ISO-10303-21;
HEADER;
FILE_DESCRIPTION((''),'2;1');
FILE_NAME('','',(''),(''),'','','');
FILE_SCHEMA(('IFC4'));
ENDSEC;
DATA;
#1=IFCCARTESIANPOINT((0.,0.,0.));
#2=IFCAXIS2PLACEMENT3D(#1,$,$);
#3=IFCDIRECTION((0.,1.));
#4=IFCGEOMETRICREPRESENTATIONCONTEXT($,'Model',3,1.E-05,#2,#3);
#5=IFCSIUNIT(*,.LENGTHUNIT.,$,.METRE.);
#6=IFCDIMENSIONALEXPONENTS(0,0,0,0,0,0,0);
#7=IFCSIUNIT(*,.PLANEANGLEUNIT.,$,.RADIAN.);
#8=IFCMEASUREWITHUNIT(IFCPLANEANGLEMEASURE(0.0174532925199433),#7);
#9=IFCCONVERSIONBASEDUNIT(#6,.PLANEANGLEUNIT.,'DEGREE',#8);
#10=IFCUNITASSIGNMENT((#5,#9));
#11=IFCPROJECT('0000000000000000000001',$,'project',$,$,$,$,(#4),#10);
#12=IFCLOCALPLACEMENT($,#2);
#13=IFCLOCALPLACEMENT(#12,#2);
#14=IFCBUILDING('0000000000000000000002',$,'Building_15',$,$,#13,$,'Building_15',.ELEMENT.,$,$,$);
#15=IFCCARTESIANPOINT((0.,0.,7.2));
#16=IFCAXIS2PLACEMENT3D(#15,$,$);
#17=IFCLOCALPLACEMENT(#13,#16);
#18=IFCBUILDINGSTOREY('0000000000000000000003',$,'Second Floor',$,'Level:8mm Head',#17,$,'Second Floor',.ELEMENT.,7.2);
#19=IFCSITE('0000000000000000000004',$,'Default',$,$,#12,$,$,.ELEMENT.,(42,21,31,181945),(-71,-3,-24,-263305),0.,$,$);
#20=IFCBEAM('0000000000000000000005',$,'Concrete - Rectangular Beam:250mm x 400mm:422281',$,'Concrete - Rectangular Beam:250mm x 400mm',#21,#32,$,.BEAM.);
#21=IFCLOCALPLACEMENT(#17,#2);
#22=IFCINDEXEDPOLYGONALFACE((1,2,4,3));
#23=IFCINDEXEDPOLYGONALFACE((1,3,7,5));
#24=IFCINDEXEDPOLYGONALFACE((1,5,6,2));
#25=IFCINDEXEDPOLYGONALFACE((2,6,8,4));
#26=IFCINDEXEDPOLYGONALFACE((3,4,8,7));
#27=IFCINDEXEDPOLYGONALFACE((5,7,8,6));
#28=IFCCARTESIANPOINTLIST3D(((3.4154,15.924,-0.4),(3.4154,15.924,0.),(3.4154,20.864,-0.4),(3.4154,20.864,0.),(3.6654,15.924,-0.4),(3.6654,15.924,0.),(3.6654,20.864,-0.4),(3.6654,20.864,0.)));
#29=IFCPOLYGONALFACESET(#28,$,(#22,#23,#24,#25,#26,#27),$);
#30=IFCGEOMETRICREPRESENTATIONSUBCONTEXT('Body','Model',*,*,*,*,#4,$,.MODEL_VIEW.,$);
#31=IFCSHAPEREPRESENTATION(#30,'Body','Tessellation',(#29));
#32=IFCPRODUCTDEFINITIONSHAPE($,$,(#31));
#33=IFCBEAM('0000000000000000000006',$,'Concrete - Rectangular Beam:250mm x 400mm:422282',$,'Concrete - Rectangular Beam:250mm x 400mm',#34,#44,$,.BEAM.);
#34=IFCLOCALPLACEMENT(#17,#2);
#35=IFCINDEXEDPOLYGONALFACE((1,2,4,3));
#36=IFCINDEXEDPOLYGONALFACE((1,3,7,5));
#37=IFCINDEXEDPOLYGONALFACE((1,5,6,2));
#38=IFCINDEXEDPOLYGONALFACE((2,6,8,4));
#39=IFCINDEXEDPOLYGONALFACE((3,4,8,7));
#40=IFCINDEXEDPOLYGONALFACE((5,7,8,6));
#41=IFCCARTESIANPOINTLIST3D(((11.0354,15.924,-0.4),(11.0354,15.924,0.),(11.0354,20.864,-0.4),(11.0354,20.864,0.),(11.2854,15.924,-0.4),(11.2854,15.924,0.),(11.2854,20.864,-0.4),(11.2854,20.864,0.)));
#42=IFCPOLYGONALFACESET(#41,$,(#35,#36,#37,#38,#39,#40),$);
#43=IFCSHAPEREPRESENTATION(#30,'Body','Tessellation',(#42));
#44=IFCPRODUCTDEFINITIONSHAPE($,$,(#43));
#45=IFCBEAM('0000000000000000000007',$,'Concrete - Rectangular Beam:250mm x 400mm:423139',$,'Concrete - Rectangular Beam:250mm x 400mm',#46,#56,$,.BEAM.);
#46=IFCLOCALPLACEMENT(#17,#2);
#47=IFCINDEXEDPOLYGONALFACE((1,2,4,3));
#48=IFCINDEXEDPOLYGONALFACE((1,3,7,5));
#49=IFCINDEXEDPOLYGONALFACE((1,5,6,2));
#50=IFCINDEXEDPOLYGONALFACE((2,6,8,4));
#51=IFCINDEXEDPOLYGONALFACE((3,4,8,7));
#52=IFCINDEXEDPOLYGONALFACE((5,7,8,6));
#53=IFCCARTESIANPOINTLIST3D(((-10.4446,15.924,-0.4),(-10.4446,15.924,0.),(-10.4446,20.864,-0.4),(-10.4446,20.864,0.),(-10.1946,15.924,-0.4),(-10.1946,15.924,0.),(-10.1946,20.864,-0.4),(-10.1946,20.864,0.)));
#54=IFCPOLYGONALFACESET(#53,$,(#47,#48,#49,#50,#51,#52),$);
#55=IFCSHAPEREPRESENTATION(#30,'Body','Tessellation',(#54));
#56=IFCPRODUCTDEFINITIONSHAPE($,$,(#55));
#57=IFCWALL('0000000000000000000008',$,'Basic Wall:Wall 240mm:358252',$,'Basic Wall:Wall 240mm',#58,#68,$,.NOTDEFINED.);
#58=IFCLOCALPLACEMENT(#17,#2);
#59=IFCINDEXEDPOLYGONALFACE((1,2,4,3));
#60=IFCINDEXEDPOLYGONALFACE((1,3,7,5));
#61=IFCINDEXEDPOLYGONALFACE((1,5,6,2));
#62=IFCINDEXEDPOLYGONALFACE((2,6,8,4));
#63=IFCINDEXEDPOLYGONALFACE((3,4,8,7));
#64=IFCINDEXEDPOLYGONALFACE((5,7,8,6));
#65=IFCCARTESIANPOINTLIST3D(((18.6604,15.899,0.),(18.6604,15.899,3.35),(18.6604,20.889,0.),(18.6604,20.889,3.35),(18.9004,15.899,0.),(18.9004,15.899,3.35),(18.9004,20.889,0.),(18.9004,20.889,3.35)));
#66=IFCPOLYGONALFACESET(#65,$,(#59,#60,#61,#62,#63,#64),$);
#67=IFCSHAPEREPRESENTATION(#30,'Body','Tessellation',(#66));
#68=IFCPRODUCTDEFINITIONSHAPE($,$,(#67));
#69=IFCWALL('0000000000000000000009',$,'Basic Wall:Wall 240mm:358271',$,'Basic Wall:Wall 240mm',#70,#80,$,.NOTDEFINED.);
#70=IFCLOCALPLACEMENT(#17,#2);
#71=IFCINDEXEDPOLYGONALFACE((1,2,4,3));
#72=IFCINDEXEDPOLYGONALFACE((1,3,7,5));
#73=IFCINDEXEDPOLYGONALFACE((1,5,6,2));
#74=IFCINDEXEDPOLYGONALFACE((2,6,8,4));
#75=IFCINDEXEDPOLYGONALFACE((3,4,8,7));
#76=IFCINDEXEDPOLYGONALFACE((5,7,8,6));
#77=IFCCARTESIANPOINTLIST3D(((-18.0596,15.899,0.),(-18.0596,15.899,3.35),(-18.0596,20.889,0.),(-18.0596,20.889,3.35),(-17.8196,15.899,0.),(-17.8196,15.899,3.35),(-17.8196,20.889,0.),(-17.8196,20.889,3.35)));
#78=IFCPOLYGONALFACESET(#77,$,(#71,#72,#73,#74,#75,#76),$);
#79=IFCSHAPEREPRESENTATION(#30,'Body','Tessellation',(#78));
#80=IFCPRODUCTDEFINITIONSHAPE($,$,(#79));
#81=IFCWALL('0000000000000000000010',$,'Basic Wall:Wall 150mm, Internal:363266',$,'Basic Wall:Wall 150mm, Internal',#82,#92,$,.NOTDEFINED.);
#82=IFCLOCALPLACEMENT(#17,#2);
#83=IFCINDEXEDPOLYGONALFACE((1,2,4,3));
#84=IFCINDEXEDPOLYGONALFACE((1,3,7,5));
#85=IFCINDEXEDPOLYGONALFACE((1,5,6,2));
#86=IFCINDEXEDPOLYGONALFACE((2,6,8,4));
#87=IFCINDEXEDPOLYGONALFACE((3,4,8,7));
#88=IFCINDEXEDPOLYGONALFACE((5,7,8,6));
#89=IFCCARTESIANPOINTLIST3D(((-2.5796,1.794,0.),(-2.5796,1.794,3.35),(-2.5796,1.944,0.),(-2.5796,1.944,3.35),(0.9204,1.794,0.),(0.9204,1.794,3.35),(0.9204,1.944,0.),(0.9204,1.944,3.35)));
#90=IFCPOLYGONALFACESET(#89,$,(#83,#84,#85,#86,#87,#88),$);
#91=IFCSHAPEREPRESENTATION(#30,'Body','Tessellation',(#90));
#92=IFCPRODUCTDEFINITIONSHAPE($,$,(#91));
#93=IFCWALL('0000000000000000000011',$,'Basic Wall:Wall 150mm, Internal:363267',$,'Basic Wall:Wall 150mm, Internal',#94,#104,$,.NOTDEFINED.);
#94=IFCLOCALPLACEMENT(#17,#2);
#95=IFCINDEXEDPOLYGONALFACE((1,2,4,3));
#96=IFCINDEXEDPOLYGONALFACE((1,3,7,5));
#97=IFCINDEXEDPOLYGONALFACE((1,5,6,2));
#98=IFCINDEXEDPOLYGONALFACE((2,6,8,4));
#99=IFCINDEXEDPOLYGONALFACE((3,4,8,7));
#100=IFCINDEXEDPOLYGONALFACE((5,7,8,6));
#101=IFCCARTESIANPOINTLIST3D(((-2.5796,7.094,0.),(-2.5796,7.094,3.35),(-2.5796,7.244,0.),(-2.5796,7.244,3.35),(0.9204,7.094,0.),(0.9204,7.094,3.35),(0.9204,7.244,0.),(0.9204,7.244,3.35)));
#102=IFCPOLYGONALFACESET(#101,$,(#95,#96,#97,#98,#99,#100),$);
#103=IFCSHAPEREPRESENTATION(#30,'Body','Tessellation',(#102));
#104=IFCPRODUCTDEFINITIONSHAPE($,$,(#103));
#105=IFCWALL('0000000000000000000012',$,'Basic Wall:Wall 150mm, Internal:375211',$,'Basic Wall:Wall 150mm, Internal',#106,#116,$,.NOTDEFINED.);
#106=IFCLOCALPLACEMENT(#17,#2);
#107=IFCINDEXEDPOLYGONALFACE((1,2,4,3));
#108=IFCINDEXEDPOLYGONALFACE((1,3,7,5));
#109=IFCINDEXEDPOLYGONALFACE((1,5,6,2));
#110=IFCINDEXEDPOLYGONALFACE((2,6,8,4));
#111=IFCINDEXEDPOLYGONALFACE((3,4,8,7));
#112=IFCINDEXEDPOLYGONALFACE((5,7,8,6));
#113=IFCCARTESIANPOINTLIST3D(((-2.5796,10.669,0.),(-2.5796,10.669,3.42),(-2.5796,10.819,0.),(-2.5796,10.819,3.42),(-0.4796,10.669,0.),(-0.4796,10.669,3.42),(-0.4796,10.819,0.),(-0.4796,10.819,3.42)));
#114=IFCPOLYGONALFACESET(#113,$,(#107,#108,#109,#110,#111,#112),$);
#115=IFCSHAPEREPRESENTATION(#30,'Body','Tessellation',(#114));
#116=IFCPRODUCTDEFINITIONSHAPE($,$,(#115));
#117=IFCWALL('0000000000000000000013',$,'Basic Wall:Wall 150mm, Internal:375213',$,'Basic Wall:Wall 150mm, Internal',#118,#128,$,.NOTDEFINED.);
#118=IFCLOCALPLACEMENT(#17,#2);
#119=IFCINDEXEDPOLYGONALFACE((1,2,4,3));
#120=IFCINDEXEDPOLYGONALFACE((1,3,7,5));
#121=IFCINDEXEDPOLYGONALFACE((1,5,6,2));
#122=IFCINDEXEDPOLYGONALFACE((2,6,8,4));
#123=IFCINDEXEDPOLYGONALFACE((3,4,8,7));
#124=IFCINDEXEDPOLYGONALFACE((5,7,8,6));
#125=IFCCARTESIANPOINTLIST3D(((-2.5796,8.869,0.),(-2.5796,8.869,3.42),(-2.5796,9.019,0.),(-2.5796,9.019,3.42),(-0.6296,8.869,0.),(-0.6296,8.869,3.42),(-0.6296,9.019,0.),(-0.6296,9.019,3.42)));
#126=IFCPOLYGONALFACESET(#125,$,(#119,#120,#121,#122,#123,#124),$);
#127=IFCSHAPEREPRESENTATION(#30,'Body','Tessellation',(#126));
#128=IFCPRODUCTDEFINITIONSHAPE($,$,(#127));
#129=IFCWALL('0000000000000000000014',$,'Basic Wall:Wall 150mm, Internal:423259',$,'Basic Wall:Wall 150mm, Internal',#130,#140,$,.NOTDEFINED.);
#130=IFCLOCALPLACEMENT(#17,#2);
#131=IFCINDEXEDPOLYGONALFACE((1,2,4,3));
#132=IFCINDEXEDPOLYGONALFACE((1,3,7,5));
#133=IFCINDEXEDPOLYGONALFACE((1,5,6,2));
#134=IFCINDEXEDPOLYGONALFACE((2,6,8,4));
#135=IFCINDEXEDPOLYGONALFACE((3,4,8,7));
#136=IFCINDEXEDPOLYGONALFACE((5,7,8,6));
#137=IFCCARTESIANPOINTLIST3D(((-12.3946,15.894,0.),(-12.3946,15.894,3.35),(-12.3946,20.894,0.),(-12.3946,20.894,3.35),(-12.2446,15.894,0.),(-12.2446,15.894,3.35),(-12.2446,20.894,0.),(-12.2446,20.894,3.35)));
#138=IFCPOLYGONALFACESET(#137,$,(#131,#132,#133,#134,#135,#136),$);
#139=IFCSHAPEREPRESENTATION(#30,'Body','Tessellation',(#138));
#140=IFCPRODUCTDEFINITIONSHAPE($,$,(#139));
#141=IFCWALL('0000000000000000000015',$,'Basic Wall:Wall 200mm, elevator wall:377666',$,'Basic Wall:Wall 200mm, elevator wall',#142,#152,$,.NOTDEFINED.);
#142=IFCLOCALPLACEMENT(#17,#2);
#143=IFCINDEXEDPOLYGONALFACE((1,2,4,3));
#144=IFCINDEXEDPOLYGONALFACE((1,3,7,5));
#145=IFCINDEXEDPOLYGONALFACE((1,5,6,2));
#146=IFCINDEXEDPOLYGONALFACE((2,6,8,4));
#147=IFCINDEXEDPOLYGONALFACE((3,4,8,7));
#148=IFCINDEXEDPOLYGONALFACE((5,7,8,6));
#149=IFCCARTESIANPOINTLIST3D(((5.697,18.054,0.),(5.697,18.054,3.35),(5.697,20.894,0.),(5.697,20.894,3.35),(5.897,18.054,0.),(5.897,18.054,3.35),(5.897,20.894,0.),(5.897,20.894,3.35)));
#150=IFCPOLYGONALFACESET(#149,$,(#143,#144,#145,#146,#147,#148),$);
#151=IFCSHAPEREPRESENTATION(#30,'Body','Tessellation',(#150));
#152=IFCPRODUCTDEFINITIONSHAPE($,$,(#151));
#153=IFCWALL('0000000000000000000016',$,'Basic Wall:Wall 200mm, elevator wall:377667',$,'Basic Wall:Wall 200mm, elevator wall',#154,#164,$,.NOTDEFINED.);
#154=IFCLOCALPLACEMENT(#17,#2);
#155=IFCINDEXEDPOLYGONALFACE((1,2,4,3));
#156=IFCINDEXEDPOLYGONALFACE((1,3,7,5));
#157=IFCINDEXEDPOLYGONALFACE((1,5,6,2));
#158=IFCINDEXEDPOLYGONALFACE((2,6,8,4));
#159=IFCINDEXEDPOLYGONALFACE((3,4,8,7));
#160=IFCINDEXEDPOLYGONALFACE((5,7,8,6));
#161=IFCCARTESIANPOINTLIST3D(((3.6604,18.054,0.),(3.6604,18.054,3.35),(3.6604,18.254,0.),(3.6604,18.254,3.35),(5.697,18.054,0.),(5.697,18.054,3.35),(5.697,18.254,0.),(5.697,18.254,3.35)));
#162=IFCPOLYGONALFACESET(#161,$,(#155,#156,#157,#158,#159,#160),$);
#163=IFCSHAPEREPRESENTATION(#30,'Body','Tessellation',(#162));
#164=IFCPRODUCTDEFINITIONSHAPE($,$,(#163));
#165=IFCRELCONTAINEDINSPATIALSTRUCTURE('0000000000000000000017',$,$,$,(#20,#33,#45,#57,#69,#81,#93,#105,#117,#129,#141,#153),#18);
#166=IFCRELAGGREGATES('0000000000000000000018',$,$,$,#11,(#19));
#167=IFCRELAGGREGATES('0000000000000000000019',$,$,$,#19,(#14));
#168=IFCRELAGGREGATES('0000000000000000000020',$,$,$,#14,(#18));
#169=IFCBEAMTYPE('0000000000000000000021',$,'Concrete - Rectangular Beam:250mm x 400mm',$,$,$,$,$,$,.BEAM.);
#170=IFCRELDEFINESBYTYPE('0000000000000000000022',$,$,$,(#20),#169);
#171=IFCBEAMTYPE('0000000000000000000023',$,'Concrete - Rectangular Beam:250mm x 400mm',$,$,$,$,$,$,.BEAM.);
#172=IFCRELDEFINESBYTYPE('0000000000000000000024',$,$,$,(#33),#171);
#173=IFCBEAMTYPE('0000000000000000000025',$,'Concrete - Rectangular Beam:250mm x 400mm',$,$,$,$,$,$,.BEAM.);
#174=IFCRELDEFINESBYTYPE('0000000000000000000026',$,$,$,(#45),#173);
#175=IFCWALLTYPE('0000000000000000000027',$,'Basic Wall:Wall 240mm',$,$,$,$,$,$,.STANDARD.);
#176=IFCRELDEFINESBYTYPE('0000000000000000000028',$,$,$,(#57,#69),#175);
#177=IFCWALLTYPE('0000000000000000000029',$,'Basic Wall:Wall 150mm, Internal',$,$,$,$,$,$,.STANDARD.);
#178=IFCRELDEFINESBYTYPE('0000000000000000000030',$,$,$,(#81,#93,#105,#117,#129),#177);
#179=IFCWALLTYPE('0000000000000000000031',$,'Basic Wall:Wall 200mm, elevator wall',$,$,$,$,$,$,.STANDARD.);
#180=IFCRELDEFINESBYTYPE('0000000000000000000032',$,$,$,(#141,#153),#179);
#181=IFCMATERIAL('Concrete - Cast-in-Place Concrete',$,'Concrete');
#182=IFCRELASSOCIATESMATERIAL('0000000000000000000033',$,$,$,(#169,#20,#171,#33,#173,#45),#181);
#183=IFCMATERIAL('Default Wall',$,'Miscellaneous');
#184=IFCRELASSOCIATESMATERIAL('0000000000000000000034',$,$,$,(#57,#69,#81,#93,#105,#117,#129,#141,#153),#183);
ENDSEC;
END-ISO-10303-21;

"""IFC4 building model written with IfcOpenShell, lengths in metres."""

from ifc_helpers import new_model, entity, si_unit, converted_unit, direction, frame, origin, place, context, subcontext, project, spatial, indexed_curve, outline, extrude, source, transform, mapped, material, type_object, type_shapes, element, save


model = new_model("IFC4")

# Units and contexts
model_context = context("Model", 3, precision=1e-05, world=origin(), true_north=direction((0.0, 1.0)))
body_context = subcontext(model_context, "Body", "Model", "MODEL_VIEW")
ifc_project = project(units=[si_unit("LENGTHUNIT", "METRE"), converted_unit("PLANEANGLEUNIT", "DEGREE", entity("IfcPlaneAngleMeasure", 0.0174532925199433), si_unit("PLANEANGLEUNIT", "RADIAN"), dimensions=[0, 0, 0, 0, 0, 0, 0])], contexts=[model_context])

# Site, building, storey
site_placement = place(None, origin())
site = spatial("IfcSite", under=ifc_project, at=site_placement, Name="Default", CompositionType="ELEMENT", RefLatitude=(42, 21, 31, 181945), RefLongitude=(-71, -3, -24, -263305), RefElevation=0.0)
building_placement = place(site_placement, origin())
building = spatial("IfcBuilding", under=site, at=building_placement, Name="Building_15", LongName="Building_15", CompositionType="ELEMENT")
storey_placement = place(building_placement, frame((0.0, 0.0, 7.2)))
storey = spatial("IfcBuildingStorey", under=building, at=storey_placement, Name="Second Floor", ObjectType="Level:8mm Head", LongName="Second Floor", CompositionType="ELEMENT", Elevation=7.2)

# Shared definitions
ifc_material_1 = material(Name="Concrete - Cast-in-Place Concrete", Category="Concrete")

# Beams
beam_type_1 = type_object("IfcBeamType", Name="Concrete - Rectangular Beam:250mm x 400mm", PredefinedType="BEAM", material=ifc_material_1)
shared_shape_1 = source(origin(), body_context, "Body", "SweptSolid", [
    extrude(outline(indexed_curve([(-0.125, -0.2), (0.125, -0.2), (0.125, 0.2), (-0.125, 0.2), (-0.125, -0.2)], self_intersect=False)), frame((3.5404, 20.864, 7.0), z_axis=(0.0, -1.0, 0.0), x_axis=(-1.0, 0.0, 0.0)), (0.0, 0.0, 1.0), 4.94),
])
type_shapes(beam_type_1, [shared_shape_1])
beam_1_placement = place(storey_placement, frame((0.0, 0.0, -7.2)))
element("IfcBeam", 1, at=beam_1_placement, inside=storey, type_object=beam_type_1, material=ifc_material_1, Name="Concrete - Rectangular Beam:250mm x 400mm:422281", ObjectType="Concrete - Rectangular Beam:250mm x 400mm", PredefinedType="BEAM", context=body_context, shape_type="MappedRepresentation", body=[
    mapped(shared_shape_1, transform((0.0, 0.0, 0.0), scale=1.0)),
])
beam_type_2 = type_object("IfcBeamType", Name="Concrete - Rectangular Beam:250mm x 400mm", PredefinedType="BEAM", material=ifc_material_1)
shared_shape_2 = source(origin(), body_context, "Body", "SweptSolid", [
    extrude(outline(indexed_curve([(-0.125, -0.2), (0.125, -0.2), (0.125, 0.2), (-0.125, 0.2), (-0.125, -0.2)], self_intersect=False)), frame((11.1604, 20.864, 7.0), z_axis=(0.0, -1.0, 0.0), x_axis=(-1.0, 0.0, 0.0)), (0.0, 0.0, 1.0), 4.94),
])
type_shapes(beam_type_2, [shared_shape_2])
beam_2_placement = place(storey_placement, frame((0.0, 0.0, -7.2)))
element("IfcBeam", 2, at=beam_2_placement, inside=storey, type_object=beam_type_2, material=ifc_material_1, Name="Concrete - Rectangular Beam:250mm x 400mm:422282", ObjectType="Concrete - Rectangular Beam:250mm x 400mm", PredefinedType="BEAM", context=body_context, shape_type="MappedRepresentation", body=[
    mapped(shared_shape_2, transform((0.0, 0.0, 0.0), scale=1.0)),
])
beam_type_3 = type_object("IfcBeamType", Name="Concrete - Rectangular Beam:250mm x 400mm", PredefinedType="BEAM", material=ifc_material_1)
shared_shape_3 = source(origin(), body_context, "Body", "SweptSolid", [
    extrude(outline(indexed_curve([(-0.125, -0.2), (0.125, -0.2), (0.125, 0.2), (-0.125, 0.2), (-0.125, -0.2)], self_intersect=False)), frame((-10.3196, 20.864, 7.0), z_axis=(0.0, -1.0, 0.0), x_axis=(-1.0, 0.0, 0.0)), (0.0, 0.0, 1.0), 4.94),
])
type_shapes(beam_type_3, [shared_shape_3])
beam_3_placement = place(storey_placement, frame((0.0, 0.0, -7.2)))
element("IfcBeam", 3, at=beam_3_placement, inside=storey, type_object=beam_type_3, material=ifc_material_1, Name="Concrete - Rectangular Beam:250mm x 400mm:423139", ObjectType="Concrete - Rectangular Beam:250mm x 400mm", PredefinedType="BEAM", context=body_context, shape_type="MappedRepresentation", body=[
    mapped(shared_shape_3, transform((0.0, 0.0, 0.0), scale=1.0)),
])

# Walls
ifc_material_2 = material(Name="Default Wall", Category="Miscellaneous")
wall_type_1 = type_object("IfcWallType", Name="Basic Wall:Wall 240mm", PredefinedType="STANDARD")
wall_1_placement = place(storey_placement, frame((18.7804, 20.889, 0.0), z_axis=(0.0, 0.0, 1.0), x_axis=(0.0, -1.0, 0.0)))
element("IfcWall", 4, at=wall_1_placement, inside=storey, type_object=wall_type_1, material=ifc_material_2, Name="Basic Wall:Wall 240mm:358252", ObjectType="Basic Wall:Wall 240mm", PredefinedType="NOTDEFINED", context=body_context, shape_type="SweptSolid", body=[
    extrude(outline(indexed_curve([(4.99, 0.12), (0.0, 0.12), (0.0, -0.12), (4.99, -0.12), (4.99, 0.12)], self_intersect=False)), origin(), (0.0, 0.0, 1.0), 3.35),
])
wall_2_placement = place(storey_placement, frame((-17.9396, 15.899, 0.0), z_axis=(0.0, 0.0, 1.0), x_axis=(0.0, 1.0, 0.0)))
element("IfcWall", 5, at=wall_2_placement, inside=storey, type_object=wall_type_1, material=ifc_material_2, Name="Basic Wall:Wall 240mm:358271", ObjectType="Basic Wall:Wall 240mm", PredefinedType="NOTDEFINED", context=body_context, shape_type="SweptSolid", body=[
    extrude(outline(indexed_curve([(4.99, 0.12), (0.0, 0.12), (0.0, -0.12), (4.99, -0.12), (4.99, 0.12)], self_intersect=False)), origin(), (0.0, 0.0, 1.0), 3.35),
])
wall_type_2 = type_object("IfcWallType", Name="Basic Wall:Wall 150mm, Internal", PredefinedType="STANDARD")
wall_3_placement = place(storey_placement, frame((0.9204, 1.869, 0.0), z_axis=(0.0, 0.0, 1.0), x_axis=(-1.0, 0.0, 0.0)))
element("IfcWall", 6, at=wall_3_placement, inside=storey, type_object=wall_type_2, material=ifc_material_2, Name="Basic Wall:Wall 150mm, Internal:363266", ObjectType="Basic Wall:Wall 150mm, Internal", PredefinedType="NOTDEFINED", context=body_context, shape_type="SweptSolid", body=[
    extrude(outline(indexed_curve([(3.5, 0.075), (0.0, 0.075), (0.0, -0.075), (3.5, -0.075), (3.5, 0.075)], self_intersect=False)), origin(), (0.0, 0.0, 1.0), 3.35),
])
wall_4_placement = place(storey_placement, frame((0.9204, 7.169, 0.0), z_axis=(0.0, 0.0, 1.0), x_axis=(-1.0, 0.0, 0.0)))
element("IfcWall", 7, at=wall_4_placement, inside=storey, type_object=wall_type_2, material=ifc_material_2, Name="Basic Wall:Wall 150mm, Internal:363267", ObjectType="Basic Wall:Wall 150mm, Internal", PredefinedType="NOTDEFINED", context=body_context, shape_type="SweptSolid", body=[
    extrude(outline(indexed_curve([(3.5, 0.075), (0.0, 0.075), (0.0, -0.075), (3.5, -0.075), (3.5, 0.075)], self_intersect=False)), origin(), (0.0, 0.0, 1.0), 3.35),
])
wall_5_placement = place(storey_placement, frame((-2.5796, 10.744, 0.0)))
element("IfcWall", 8, at=wall_5_placement, inside=storey, type_object=wall_type_2, material=ifc_material_2, Name="Basic Wall:Wall 150mm, Internal:375211", ObjectType="Basic Wall:Wall 150mm, Internal", PredefinedType="NOTDEFINED", context=body_context, shape_type="SweptSolid", body=[
    extrude(outline(indexed_curve([(2.1, 0.075), (0.0, 0.075), (0.0, -0.075), (2.1, -0.075), (2.1, 0.075)], self_intersect=False)), origin(), (0.0, 0.0, 1.0), 3.42),
])
wall_6_placement = place(storey_placement, frame((-2.5796, 8.944, 0.0)))
element("IfcWall", 9, at=wall_6_placement, inside=storey, type_object=wall_type_2, material=ifc_material_2, Name="Basic Wall:Wall 150mm, Internal:375213", ObjectType="Basic Wall:Wall 150mm, Internal", PredefinedType="NOTDEFINED", context=body_context, shape_type="SweptSolid", body=[
    extrude(outline(indexed_curve([(1.95, 0.075), (0.0, 0.075), (0.0, -0.075), (1.95, -0.075), (1.95, 0.075)], self_intersect=False)), origin(), (0.0, 0.0, 1.0), 3.42),
])
wall_7_placement = place(storey_placement, frame((-12.3196, 20.894, 0.0), z_axis=(0.0, 0.0, 1.0), x_axis=(0.0, -1.0, 0.0)))
element("IfcWall", 10, at=wall_7_placement, inside=storey, type_object=wall_type_2, material=ifc_material_2, Name="Basic Wall:Wall 150mm, Internal:423259", ObjectType="Basic Wall:Wall 150mm, Internal", PredefinedType="NOTDEFINED", context=body_context, shape_type="SweptSolid", body=[
    extrude(outline(indexed_curve([(5.0, 0.075), (0.0, 0.075), (0.0, -0.075), (5.0, -0.075), (5.0, 0.075)], self_intersect=False)), origin(), (0.0, 0.0, 1.0), 3.35),
])
wall_type_3 = type_object("IfcWallType", Name="Basic Wall:Wall 200mm, elevator wall", PredefinedType="STANDARD")
wall_8_placement = place(storey_placement, frame((5.797, 20.894, 0.0), z_axis=(0.0, 0.0, 1.0), x_axis=(0.0, -1.0, 0.0)))
element("IfcWall", 11, at=wall_8_placement, inside=storey, type_object=wall_type_3, material=ifc_material_2, Name="Basic Wall:Wall 200mm, elevator wall:377666", ObjectType="Basic Wall:Wall 200mm, elevator wall", PredefinedType="NOTDEFINED", context=body_context, shape_type="SweptSolid", body=[
    extrude(outline(indexed_curve([(2.84, 0.1), (0.0, 0.1), (0.0, -0.1), (2.84, -0.1), (2.84, 0.1)], self_intersect=False)), origin(), (0.0, 0.0, 1.0), 3.35),
])
wall_9_placement = place(storey_placement, frame((5.697, 18.154, 0.0), z_axis=(0.0, 0.0, 1.0), x_axis=(-1.0, 0.0, 0.0)))
element("IfcWall", 12, at=wall_9_placement, inside=storey, type_object=wall_type_3, material=ifc_material_2, Name="Basic Wall:Wall 200mm, elevator wall:377667", ObjectType="Basic Wall:Wall 200mm, elevator wall", PredefinedType="NOTDEFINED", context=body_context, shape_type="SweptSolid", body=[
    extrude(outline(indexed_curve([(2.0366, 0.1), (0.0, 0.1), (0.0, -0.1), (2.0366, -0.1), (2.0366, 0.1)], self_intersect=False)), origin(), (0.0, 0.0, 1.0), 3.35),
])

save(model, "model.ifc")
